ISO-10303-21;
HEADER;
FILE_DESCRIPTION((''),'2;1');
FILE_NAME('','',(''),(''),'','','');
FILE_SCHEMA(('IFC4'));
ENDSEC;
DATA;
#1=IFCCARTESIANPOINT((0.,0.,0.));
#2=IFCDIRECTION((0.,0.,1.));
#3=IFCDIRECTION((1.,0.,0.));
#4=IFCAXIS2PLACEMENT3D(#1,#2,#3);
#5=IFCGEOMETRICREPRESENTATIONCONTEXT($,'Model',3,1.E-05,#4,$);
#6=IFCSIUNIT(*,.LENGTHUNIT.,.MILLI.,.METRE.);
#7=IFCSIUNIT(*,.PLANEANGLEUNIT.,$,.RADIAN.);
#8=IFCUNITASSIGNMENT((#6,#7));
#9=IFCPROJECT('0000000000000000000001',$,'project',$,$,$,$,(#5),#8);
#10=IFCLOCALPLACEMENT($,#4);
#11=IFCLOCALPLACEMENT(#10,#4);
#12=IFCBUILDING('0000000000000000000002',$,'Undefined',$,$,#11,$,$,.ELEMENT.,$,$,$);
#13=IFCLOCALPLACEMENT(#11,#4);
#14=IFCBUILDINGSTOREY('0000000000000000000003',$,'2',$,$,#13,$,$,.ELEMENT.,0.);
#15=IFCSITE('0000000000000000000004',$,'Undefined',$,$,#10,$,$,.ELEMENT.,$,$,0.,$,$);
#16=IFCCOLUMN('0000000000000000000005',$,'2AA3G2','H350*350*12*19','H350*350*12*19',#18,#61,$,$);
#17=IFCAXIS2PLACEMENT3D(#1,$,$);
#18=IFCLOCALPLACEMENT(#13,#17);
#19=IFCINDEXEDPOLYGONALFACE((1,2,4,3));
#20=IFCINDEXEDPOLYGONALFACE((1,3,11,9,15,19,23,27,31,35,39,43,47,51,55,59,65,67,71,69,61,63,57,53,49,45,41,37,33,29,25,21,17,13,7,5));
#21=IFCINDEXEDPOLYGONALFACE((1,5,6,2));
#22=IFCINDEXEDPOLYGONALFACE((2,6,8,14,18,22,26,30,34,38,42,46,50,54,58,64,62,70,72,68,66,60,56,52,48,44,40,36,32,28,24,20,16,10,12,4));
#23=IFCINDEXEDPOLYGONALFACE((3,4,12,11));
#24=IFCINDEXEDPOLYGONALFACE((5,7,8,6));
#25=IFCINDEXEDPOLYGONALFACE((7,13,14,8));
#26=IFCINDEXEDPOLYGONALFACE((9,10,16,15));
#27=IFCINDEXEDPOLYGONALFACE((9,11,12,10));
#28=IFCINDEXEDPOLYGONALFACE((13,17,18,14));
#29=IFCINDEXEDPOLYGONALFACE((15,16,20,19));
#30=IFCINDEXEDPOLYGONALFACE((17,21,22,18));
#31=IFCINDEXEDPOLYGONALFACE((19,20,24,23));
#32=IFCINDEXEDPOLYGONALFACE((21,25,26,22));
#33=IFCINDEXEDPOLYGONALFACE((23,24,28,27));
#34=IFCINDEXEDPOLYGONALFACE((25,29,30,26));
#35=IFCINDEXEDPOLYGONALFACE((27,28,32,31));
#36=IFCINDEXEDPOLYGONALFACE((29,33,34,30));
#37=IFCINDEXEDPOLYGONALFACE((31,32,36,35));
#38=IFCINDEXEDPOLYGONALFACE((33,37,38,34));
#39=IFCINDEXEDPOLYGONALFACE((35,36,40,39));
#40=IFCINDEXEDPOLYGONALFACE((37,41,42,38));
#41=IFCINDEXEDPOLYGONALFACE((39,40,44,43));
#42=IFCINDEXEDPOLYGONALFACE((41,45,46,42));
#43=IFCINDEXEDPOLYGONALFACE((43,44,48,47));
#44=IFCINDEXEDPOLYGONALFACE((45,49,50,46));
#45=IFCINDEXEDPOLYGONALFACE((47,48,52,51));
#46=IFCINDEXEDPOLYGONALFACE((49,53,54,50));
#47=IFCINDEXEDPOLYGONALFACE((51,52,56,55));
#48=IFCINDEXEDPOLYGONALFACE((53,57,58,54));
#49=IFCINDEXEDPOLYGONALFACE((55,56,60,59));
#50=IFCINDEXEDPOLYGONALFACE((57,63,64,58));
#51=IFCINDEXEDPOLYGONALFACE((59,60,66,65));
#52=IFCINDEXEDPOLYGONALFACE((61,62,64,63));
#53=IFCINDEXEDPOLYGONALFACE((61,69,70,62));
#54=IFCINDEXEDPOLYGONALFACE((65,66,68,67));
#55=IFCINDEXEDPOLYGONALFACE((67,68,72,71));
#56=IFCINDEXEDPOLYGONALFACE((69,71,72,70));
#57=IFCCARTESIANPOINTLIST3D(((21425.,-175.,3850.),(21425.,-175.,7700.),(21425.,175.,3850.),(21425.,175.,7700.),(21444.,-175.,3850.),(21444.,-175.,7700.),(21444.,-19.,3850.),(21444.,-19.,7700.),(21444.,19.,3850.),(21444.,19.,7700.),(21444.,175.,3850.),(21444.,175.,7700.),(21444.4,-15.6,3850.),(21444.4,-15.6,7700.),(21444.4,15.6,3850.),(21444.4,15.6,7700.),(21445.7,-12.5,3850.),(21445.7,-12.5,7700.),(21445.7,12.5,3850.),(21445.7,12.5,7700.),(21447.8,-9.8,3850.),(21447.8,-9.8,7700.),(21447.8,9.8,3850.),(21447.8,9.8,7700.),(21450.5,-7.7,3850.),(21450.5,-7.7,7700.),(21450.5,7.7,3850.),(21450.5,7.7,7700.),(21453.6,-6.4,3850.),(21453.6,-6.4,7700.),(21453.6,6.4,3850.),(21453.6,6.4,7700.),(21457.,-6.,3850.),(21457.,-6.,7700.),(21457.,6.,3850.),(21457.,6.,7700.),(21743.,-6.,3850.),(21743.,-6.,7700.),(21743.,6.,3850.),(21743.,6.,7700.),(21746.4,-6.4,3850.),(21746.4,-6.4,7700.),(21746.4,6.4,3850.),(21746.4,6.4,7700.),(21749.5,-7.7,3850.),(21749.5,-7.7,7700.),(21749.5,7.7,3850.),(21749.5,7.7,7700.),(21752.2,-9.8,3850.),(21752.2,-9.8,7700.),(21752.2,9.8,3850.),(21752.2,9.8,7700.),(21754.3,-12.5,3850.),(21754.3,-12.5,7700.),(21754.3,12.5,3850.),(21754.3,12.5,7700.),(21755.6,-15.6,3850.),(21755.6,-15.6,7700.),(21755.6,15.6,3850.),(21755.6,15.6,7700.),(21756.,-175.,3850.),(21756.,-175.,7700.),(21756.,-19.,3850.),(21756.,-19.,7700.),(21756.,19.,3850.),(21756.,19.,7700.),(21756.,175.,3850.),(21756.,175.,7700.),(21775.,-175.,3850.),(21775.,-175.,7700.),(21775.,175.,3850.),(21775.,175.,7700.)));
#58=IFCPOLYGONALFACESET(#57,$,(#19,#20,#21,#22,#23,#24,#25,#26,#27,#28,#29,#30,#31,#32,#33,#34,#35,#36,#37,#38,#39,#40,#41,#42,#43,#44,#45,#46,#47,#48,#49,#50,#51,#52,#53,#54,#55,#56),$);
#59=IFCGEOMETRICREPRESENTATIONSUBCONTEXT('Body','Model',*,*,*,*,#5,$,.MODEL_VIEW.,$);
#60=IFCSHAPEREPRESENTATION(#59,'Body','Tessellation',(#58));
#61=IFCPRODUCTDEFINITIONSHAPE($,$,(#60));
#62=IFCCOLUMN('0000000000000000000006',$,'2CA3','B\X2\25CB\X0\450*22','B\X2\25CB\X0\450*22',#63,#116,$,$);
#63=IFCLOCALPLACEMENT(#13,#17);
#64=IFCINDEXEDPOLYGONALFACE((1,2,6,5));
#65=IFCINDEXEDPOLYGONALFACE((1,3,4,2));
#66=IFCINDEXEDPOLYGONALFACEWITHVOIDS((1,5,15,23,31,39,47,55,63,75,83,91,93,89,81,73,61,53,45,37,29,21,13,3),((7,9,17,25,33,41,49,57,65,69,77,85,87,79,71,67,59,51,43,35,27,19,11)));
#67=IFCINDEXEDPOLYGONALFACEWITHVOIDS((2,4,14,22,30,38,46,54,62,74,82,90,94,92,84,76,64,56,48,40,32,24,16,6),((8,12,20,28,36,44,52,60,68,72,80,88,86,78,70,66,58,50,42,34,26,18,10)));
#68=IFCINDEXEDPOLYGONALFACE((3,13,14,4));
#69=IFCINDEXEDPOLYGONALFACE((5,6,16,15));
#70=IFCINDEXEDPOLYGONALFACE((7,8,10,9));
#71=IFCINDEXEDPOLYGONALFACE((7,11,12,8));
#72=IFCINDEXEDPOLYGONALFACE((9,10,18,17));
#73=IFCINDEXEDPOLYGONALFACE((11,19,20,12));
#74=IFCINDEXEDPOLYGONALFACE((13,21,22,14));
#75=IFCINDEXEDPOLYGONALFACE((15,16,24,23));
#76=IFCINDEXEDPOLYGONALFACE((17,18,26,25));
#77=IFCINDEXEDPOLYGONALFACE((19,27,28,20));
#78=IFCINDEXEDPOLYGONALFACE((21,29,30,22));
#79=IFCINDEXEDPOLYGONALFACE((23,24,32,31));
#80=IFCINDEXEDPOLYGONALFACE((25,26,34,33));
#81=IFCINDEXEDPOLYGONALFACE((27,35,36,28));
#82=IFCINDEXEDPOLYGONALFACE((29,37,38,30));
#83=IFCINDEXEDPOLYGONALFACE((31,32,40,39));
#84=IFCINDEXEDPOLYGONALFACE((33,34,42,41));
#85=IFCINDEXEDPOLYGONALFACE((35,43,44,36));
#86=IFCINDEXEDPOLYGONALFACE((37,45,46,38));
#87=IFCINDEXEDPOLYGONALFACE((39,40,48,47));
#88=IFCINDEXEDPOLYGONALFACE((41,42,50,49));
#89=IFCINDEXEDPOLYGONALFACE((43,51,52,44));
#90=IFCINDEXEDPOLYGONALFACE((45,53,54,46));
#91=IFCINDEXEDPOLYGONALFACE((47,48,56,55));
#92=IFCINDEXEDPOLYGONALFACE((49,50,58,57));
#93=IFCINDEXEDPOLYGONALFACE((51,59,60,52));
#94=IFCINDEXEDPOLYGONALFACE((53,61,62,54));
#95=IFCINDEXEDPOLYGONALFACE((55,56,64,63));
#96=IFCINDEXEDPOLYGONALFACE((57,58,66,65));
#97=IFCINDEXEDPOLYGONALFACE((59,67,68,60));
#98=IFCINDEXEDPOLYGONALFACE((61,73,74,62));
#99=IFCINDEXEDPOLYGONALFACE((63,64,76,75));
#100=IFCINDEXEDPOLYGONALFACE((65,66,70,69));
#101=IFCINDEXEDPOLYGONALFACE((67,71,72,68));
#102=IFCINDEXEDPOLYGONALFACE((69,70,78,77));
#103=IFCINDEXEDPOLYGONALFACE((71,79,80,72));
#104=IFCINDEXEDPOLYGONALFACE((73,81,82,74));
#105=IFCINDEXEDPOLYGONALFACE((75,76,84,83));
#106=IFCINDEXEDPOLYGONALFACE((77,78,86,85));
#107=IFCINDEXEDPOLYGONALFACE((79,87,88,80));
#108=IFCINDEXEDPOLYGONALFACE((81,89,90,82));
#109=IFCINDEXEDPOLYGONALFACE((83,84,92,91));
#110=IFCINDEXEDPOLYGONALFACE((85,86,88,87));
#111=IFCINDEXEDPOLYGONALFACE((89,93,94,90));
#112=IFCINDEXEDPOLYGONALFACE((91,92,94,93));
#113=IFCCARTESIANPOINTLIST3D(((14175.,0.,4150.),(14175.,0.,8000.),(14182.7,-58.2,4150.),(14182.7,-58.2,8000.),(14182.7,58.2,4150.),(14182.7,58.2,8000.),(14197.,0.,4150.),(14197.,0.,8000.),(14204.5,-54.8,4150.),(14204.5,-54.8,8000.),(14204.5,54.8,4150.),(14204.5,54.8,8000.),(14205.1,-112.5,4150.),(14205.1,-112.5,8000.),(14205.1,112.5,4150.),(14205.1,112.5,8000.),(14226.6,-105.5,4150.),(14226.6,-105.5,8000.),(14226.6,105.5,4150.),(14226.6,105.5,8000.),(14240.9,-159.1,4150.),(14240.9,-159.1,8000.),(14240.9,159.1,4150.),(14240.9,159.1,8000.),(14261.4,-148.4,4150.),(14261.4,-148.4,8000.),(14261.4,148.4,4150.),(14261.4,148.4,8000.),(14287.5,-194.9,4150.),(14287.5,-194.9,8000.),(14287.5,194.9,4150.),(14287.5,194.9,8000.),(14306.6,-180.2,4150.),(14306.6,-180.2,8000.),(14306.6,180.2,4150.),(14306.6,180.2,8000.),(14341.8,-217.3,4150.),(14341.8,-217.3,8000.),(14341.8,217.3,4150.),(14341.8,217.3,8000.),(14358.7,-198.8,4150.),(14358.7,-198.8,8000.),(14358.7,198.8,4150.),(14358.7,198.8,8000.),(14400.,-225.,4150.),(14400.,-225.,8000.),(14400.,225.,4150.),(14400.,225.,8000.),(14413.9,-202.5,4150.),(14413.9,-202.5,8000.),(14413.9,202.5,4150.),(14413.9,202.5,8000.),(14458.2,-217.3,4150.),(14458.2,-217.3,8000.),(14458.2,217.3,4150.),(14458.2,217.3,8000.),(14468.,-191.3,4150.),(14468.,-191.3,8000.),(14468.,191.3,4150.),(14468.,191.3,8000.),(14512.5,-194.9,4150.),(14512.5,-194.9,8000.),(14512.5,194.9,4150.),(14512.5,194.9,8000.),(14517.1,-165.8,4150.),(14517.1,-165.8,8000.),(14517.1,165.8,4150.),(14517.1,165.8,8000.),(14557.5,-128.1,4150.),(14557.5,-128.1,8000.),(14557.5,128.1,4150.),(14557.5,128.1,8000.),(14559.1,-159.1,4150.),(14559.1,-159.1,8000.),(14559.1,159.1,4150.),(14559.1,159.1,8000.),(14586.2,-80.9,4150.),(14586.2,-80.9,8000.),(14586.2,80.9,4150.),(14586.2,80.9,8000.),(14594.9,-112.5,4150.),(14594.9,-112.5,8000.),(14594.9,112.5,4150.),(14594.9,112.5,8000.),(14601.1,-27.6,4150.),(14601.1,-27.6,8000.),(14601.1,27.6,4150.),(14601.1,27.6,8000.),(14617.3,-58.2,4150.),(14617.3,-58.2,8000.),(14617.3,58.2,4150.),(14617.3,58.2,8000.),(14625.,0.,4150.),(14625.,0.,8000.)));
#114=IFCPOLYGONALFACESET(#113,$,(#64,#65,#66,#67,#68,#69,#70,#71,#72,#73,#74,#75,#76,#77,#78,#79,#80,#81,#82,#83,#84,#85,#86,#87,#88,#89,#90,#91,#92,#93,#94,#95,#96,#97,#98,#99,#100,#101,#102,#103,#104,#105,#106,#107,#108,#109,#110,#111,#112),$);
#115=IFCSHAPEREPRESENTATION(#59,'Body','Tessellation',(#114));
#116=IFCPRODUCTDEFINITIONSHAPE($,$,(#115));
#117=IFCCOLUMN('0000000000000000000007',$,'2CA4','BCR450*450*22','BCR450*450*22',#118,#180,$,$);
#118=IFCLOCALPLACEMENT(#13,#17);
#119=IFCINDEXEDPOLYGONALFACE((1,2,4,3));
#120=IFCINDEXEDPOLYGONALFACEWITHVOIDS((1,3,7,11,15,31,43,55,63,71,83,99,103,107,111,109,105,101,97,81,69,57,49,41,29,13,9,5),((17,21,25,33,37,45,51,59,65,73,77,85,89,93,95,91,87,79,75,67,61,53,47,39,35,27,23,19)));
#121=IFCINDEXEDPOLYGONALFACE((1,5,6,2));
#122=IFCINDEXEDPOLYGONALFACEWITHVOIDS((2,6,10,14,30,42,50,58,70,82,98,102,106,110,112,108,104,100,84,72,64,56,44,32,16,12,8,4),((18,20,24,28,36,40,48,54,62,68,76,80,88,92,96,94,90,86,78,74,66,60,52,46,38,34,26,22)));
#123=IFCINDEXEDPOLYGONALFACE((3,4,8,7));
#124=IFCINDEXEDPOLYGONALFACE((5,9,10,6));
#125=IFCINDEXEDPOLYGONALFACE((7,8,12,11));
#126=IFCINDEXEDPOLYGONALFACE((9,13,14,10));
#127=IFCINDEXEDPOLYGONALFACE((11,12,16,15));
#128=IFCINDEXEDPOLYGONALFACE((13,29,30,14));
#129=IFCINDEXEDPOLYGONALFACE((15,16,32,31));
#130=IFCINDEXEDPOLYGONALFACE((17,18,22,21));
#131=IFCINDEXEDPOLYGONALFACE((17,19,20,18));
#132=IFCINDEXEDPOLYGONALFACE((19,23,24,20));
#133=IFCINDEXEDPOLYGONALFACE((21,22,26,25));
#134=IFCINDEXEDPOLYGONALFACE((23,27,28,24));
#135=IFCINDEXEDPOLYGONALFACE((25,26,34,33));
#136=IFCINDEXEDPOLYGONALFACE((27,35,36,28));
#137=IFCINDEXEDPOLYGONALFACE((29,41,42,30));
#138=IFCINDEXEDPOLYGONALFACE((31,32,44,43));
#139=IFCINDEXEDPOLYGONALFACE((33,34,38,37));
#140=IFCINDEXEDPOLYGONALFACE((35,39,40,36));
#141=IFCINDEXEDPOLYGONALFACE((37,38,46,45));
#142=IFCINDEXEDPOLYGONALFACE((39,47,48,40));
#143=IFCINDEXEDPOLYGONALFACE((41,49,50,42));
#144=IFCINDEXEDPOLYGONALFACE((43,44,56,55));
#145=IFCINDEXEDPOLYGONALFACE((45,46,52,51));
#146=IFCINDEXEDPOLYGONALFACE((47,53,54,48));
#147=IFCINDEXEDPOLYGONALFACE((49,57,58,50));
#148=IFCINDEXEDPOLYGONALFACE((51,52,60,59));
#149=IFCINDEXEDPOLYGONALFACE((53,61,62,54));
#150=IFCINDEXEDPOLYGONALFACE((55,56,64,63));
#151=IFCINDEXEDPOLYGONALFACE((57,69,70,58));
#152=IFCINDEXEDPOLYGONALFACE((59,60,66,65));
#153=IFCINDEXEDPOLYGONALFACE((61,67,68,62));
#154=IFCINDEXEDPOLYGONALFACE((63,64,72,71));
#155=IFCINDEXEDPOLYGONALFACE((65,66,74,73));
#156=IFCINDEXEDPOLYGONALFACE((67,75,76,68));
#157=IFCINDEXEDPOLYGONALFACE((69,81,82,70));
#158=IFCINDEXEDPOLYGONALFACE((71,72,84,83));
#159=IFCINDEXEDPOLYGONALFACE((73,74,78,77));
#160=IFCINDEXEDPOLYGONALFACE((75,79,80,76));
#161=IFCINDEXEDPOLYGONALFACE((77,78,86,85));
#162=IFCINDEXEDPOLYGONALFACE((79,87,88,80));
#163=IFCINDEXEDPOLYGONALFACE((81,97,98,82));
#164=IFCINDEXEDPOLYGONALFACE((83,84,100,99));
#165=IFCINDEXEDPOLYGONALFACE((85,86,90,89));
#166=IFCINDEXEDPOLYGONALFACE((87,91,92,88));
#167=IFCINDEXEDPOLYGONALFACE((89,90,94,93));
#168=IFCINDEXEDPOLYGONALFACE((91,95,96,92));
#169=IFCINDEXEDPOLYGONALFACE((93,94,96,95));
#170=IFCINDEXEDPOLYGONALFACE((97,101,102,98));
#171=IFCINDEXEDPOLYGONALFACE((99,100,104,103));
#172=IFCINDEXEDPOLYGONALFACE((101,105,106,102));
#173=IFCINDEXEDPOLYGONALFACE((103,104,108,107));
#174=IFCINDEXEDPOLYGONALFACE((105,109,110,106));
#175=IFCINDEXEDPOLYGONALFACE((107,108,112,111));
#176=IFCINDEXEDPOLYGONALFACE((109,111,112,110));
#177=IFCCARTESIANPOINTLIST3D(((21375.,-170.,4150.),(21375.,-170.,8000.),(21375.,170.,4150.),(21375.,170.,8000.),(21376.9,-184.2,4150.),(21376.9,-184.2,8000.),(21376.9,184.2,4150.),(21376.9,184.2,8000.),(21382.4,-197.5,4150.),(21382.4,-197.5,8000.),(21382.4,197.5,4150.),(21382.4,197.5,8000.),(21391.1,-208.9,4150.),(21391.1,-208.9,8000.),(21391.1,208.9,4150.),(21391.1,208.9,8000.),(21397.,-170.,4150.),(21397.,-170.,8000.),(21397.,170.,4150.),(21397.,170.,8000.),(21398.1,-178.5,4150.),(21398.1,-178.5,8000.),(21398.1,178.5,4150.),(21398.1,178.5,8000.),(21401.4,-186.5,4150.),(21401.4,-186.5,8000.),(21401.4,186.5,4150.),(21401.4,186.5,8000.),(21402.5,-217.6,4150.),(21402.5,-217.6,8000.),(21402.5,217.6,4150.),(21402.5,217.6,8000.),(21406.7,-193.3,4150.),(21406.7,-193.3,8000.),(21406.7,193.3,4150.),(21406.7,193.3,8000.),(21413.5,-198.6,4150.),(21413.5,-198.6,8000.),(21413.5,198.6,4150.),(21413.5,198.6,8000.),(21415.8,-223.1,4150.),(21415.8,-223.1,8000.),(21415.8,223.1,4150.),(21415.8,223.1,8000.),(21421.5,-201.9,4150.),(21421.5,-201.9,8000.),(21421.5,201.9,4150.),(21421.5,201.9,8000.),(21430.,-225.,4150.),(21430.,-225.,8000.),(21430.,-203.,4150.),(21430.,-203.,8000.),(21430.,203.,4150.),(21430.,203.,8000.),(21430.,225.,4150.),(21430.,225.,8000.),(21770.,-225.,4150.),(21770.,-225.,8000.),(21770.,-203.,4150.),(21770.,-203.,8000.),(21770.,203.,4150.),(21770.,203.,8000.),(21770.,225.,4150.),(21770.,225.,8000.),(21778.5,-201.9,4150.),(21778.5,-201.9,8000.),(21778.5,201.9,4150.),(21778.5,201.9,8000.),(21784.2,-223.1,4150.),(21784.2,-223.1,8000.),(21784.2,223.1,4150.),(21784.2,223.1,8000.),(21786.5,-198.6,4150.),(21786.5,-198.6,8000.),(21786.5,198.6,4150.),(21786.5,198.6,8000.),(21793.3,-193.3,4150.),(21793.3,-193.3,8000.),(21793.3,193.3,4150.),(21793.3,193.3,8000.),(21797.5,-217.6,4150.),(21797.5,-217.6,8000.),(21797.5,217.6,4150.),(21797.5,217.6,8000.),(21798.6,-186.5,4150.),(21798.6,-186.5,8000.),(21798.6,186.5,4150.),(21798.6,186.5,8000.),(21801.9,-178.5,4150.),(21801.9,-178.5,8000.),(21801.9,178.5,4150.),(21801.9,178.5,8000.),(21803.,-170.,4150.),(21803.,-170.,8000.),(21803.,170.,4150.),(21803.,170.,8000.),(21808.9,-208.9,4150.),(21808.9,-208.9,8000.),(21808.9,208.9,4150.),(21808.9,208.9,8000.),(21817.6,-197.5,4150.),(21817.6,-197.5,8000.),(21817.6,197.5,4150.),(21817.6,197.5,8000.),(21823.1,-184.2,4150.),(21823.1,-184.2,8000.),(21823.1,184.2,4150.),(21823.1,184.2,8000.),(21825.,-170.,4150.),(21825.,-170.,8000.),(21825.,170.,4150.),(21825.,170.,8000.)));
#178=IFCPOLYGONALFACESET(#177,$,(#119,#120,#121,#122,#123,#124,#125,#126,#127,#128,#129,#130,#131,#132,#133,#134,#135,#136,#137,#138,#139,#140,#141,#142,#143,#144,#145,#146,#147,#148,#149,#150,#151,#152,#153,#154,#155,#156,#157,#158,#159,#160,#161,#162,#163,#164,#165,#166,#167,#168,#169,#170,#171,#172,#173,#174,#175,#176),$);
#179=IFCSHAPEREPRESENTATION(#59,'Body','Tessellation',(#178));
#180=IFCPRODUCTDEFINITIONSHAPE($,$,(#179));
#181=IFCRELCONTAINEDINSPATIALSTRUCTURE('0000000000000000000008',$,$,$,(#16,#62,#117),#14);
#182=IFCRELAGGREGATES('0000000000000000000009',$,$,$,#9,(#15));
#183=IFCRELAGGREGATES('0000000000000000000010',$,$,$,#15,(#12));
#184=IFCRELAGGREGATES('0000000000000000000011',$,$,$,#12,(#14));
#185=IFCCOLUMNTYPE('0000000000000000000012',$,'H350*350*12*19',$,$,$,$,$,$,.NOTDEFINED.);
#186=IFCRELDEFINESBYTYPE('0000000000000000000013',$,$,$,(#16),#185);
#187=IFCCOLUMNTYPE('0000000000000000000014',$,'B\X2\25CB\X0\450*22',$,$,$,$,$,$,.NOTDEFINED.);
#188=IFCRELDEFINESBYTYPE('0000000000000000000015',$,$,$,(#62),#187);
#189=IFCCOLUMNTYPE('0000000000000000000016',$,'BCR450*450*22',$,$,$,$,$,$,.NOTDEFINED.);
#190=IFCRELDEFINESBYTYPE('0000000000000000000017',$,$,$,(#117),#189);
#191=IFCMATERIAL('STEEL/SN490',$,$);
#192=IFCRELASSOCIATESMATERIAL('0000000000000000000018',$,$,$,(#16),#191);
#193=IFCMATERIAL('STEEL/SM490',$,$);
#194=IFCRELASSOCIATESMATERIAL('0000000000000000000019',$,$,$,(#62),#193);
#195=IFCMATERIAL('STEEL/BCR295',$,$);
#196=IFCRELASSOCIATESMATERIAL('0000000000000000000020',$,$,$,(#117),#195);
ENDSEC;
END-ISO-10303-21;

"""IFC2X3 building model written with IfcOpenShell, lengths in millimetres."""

from ifc_helpers import new_model, si_unit, frame, origin_with_axes, origin_2d_with_axis, place, context, subcontext, project, spatial, hollow_rectangle, hollow_circle, i_section, extrude, material, type_object, element, save


model = new_model("IFC2X3")

# Units and contexts
model_context = context("Model", 3, precision=1e-05, world=origin_with_axes())
body_context = subcontext(model_context, "Body", "Model", "MODEL_VIEW")
ifc_project = project(units=[si_unit("LENGTHUNIT", "METRE", prefix="MILLI"), si_unit("PLANEANGLEUNIT", "RADIAN")], contexts=[model_context])

# Site, building, storey
site_placement = place(None, origin_with_axes())
site = spatial("IfcSite", under=ifc_project, at=site_placement, Name="Undefined", CompositionType="ELEMENT", RefElevation=0.0)
building_placement = place(site_placement, origin_with_axes())
building = spatial("IfcBuilding", under=site, at=building_placement, Name="Undefined", CompositionType="ELEMENT")
storey_placement = place(building_placement, origin_with_axes())
storey = spatial("IfcBuildingStorey", under=building, at=storey_placement, Name="2", CompositionType="ELEMENT", Elevation=0.0)

# Columns
ifc_material_1 = material(Name="STEEL/SN490")
column_type_1 = type_object("IfcColumnType", Name="H350*350*12*19", PredefinedType="NOTDEFINED")
column_1_placement = place(storey_placement, frame((21600.0, 0.0, 3850.0), z_axis=(0.0, 0.0, 1.0), x_axis=(-1.0, 0.0, 0.0)))
element("IfcColumn", 1, at=column_1_placement, inside=storey, type_object=column_type_1, material=ifc_material_1, Name="2AA3G2", Description="H350*350*12*19", ObjectType="H350*350*12*19", context=body_context, shape_type="SweptSolid", body=[
    extrude(i_section(OverallWidth=350.0, OverallDepth=350.0, WebThickness=12.0, FlangeThickness=19.0, FilletRadius=13.0, at=origin_2d_with_axis()), frame((0.0, 0.0, 3850.0), z_axis=(0.0, 0.0, -1.0), x_axis=(0.0, 1.0, 0.0)), (0.0, 0.0, 1.0), 3850.0),
])
ifc_material_2 = material(Name="STEEL/SM490")
column_type_2 = type_object("IfcColumnType", Name="B○450*22", PredefinedType="NOTDEFINED")
column_2_placement = place(storey_placement, frame((14400.0, 0.0, 4150.0), z_axis=(0.0, 0.0, 1.0), x_axis=(0.0, 1.0, 0.0)))
element("IfcColumn", 2, at=column_2_placement, inside=storey, type_object=column_type_2, material=ifc_material_2, Name="2CA3", Description="B○450*22", ObjectType="B○450*22", context=body_context, shape_type="SweptSolid", body=[
    extrude(hollow_circle(Radius=225.0, WallThickness=22.0, at=origin_2d_with_axis()), frame((0.0, 0.0, 3850.0), z_axis=(0.0, 0.0, -1.0), x_axis=(0.0, 1.0, 0.0)), (0.0, 0.0, 1.0), 3850.0),
])
ifc_material_3 = material(Name="STEEL/BCR295")
column_type_3 = type_object("IfcColumnType", Name="BCR450*450*22", PredefinedType="NOTDEFINED")
column_3_placement = place(storey_placement, frame((21600.0, 0.0, 4150.0), z_axis=(0.0, 0.0, 1.0), x_axis=(0.0, 1.0, 0.0)))
element("IfcColumn", 3, at=column_3_placement, inside=storey, type_object=column_type_3, material=ifc_material_3, Name="2CA4", Description="BCR450*450*22", ObjectType="BCR450*450*22", context=body_context, shape_type="SweptSolid", body=[
    extrude(hollow_rectangle(XDim=450.0, YDim=450.0, WallThickness=22.0, InnerFilletRadius=33.0, OuterFilletRadius=55.0, at=origin_2d_with_axis()), frame((0.0, 0.0, 3850.0), z_axis=(0.0, 0.0, -1.0), x_axis=(0.0, 1.0, 0.0)), (0.0, 0.0, 1.0), 3850.0),
])

save(model, "model.ifc")
